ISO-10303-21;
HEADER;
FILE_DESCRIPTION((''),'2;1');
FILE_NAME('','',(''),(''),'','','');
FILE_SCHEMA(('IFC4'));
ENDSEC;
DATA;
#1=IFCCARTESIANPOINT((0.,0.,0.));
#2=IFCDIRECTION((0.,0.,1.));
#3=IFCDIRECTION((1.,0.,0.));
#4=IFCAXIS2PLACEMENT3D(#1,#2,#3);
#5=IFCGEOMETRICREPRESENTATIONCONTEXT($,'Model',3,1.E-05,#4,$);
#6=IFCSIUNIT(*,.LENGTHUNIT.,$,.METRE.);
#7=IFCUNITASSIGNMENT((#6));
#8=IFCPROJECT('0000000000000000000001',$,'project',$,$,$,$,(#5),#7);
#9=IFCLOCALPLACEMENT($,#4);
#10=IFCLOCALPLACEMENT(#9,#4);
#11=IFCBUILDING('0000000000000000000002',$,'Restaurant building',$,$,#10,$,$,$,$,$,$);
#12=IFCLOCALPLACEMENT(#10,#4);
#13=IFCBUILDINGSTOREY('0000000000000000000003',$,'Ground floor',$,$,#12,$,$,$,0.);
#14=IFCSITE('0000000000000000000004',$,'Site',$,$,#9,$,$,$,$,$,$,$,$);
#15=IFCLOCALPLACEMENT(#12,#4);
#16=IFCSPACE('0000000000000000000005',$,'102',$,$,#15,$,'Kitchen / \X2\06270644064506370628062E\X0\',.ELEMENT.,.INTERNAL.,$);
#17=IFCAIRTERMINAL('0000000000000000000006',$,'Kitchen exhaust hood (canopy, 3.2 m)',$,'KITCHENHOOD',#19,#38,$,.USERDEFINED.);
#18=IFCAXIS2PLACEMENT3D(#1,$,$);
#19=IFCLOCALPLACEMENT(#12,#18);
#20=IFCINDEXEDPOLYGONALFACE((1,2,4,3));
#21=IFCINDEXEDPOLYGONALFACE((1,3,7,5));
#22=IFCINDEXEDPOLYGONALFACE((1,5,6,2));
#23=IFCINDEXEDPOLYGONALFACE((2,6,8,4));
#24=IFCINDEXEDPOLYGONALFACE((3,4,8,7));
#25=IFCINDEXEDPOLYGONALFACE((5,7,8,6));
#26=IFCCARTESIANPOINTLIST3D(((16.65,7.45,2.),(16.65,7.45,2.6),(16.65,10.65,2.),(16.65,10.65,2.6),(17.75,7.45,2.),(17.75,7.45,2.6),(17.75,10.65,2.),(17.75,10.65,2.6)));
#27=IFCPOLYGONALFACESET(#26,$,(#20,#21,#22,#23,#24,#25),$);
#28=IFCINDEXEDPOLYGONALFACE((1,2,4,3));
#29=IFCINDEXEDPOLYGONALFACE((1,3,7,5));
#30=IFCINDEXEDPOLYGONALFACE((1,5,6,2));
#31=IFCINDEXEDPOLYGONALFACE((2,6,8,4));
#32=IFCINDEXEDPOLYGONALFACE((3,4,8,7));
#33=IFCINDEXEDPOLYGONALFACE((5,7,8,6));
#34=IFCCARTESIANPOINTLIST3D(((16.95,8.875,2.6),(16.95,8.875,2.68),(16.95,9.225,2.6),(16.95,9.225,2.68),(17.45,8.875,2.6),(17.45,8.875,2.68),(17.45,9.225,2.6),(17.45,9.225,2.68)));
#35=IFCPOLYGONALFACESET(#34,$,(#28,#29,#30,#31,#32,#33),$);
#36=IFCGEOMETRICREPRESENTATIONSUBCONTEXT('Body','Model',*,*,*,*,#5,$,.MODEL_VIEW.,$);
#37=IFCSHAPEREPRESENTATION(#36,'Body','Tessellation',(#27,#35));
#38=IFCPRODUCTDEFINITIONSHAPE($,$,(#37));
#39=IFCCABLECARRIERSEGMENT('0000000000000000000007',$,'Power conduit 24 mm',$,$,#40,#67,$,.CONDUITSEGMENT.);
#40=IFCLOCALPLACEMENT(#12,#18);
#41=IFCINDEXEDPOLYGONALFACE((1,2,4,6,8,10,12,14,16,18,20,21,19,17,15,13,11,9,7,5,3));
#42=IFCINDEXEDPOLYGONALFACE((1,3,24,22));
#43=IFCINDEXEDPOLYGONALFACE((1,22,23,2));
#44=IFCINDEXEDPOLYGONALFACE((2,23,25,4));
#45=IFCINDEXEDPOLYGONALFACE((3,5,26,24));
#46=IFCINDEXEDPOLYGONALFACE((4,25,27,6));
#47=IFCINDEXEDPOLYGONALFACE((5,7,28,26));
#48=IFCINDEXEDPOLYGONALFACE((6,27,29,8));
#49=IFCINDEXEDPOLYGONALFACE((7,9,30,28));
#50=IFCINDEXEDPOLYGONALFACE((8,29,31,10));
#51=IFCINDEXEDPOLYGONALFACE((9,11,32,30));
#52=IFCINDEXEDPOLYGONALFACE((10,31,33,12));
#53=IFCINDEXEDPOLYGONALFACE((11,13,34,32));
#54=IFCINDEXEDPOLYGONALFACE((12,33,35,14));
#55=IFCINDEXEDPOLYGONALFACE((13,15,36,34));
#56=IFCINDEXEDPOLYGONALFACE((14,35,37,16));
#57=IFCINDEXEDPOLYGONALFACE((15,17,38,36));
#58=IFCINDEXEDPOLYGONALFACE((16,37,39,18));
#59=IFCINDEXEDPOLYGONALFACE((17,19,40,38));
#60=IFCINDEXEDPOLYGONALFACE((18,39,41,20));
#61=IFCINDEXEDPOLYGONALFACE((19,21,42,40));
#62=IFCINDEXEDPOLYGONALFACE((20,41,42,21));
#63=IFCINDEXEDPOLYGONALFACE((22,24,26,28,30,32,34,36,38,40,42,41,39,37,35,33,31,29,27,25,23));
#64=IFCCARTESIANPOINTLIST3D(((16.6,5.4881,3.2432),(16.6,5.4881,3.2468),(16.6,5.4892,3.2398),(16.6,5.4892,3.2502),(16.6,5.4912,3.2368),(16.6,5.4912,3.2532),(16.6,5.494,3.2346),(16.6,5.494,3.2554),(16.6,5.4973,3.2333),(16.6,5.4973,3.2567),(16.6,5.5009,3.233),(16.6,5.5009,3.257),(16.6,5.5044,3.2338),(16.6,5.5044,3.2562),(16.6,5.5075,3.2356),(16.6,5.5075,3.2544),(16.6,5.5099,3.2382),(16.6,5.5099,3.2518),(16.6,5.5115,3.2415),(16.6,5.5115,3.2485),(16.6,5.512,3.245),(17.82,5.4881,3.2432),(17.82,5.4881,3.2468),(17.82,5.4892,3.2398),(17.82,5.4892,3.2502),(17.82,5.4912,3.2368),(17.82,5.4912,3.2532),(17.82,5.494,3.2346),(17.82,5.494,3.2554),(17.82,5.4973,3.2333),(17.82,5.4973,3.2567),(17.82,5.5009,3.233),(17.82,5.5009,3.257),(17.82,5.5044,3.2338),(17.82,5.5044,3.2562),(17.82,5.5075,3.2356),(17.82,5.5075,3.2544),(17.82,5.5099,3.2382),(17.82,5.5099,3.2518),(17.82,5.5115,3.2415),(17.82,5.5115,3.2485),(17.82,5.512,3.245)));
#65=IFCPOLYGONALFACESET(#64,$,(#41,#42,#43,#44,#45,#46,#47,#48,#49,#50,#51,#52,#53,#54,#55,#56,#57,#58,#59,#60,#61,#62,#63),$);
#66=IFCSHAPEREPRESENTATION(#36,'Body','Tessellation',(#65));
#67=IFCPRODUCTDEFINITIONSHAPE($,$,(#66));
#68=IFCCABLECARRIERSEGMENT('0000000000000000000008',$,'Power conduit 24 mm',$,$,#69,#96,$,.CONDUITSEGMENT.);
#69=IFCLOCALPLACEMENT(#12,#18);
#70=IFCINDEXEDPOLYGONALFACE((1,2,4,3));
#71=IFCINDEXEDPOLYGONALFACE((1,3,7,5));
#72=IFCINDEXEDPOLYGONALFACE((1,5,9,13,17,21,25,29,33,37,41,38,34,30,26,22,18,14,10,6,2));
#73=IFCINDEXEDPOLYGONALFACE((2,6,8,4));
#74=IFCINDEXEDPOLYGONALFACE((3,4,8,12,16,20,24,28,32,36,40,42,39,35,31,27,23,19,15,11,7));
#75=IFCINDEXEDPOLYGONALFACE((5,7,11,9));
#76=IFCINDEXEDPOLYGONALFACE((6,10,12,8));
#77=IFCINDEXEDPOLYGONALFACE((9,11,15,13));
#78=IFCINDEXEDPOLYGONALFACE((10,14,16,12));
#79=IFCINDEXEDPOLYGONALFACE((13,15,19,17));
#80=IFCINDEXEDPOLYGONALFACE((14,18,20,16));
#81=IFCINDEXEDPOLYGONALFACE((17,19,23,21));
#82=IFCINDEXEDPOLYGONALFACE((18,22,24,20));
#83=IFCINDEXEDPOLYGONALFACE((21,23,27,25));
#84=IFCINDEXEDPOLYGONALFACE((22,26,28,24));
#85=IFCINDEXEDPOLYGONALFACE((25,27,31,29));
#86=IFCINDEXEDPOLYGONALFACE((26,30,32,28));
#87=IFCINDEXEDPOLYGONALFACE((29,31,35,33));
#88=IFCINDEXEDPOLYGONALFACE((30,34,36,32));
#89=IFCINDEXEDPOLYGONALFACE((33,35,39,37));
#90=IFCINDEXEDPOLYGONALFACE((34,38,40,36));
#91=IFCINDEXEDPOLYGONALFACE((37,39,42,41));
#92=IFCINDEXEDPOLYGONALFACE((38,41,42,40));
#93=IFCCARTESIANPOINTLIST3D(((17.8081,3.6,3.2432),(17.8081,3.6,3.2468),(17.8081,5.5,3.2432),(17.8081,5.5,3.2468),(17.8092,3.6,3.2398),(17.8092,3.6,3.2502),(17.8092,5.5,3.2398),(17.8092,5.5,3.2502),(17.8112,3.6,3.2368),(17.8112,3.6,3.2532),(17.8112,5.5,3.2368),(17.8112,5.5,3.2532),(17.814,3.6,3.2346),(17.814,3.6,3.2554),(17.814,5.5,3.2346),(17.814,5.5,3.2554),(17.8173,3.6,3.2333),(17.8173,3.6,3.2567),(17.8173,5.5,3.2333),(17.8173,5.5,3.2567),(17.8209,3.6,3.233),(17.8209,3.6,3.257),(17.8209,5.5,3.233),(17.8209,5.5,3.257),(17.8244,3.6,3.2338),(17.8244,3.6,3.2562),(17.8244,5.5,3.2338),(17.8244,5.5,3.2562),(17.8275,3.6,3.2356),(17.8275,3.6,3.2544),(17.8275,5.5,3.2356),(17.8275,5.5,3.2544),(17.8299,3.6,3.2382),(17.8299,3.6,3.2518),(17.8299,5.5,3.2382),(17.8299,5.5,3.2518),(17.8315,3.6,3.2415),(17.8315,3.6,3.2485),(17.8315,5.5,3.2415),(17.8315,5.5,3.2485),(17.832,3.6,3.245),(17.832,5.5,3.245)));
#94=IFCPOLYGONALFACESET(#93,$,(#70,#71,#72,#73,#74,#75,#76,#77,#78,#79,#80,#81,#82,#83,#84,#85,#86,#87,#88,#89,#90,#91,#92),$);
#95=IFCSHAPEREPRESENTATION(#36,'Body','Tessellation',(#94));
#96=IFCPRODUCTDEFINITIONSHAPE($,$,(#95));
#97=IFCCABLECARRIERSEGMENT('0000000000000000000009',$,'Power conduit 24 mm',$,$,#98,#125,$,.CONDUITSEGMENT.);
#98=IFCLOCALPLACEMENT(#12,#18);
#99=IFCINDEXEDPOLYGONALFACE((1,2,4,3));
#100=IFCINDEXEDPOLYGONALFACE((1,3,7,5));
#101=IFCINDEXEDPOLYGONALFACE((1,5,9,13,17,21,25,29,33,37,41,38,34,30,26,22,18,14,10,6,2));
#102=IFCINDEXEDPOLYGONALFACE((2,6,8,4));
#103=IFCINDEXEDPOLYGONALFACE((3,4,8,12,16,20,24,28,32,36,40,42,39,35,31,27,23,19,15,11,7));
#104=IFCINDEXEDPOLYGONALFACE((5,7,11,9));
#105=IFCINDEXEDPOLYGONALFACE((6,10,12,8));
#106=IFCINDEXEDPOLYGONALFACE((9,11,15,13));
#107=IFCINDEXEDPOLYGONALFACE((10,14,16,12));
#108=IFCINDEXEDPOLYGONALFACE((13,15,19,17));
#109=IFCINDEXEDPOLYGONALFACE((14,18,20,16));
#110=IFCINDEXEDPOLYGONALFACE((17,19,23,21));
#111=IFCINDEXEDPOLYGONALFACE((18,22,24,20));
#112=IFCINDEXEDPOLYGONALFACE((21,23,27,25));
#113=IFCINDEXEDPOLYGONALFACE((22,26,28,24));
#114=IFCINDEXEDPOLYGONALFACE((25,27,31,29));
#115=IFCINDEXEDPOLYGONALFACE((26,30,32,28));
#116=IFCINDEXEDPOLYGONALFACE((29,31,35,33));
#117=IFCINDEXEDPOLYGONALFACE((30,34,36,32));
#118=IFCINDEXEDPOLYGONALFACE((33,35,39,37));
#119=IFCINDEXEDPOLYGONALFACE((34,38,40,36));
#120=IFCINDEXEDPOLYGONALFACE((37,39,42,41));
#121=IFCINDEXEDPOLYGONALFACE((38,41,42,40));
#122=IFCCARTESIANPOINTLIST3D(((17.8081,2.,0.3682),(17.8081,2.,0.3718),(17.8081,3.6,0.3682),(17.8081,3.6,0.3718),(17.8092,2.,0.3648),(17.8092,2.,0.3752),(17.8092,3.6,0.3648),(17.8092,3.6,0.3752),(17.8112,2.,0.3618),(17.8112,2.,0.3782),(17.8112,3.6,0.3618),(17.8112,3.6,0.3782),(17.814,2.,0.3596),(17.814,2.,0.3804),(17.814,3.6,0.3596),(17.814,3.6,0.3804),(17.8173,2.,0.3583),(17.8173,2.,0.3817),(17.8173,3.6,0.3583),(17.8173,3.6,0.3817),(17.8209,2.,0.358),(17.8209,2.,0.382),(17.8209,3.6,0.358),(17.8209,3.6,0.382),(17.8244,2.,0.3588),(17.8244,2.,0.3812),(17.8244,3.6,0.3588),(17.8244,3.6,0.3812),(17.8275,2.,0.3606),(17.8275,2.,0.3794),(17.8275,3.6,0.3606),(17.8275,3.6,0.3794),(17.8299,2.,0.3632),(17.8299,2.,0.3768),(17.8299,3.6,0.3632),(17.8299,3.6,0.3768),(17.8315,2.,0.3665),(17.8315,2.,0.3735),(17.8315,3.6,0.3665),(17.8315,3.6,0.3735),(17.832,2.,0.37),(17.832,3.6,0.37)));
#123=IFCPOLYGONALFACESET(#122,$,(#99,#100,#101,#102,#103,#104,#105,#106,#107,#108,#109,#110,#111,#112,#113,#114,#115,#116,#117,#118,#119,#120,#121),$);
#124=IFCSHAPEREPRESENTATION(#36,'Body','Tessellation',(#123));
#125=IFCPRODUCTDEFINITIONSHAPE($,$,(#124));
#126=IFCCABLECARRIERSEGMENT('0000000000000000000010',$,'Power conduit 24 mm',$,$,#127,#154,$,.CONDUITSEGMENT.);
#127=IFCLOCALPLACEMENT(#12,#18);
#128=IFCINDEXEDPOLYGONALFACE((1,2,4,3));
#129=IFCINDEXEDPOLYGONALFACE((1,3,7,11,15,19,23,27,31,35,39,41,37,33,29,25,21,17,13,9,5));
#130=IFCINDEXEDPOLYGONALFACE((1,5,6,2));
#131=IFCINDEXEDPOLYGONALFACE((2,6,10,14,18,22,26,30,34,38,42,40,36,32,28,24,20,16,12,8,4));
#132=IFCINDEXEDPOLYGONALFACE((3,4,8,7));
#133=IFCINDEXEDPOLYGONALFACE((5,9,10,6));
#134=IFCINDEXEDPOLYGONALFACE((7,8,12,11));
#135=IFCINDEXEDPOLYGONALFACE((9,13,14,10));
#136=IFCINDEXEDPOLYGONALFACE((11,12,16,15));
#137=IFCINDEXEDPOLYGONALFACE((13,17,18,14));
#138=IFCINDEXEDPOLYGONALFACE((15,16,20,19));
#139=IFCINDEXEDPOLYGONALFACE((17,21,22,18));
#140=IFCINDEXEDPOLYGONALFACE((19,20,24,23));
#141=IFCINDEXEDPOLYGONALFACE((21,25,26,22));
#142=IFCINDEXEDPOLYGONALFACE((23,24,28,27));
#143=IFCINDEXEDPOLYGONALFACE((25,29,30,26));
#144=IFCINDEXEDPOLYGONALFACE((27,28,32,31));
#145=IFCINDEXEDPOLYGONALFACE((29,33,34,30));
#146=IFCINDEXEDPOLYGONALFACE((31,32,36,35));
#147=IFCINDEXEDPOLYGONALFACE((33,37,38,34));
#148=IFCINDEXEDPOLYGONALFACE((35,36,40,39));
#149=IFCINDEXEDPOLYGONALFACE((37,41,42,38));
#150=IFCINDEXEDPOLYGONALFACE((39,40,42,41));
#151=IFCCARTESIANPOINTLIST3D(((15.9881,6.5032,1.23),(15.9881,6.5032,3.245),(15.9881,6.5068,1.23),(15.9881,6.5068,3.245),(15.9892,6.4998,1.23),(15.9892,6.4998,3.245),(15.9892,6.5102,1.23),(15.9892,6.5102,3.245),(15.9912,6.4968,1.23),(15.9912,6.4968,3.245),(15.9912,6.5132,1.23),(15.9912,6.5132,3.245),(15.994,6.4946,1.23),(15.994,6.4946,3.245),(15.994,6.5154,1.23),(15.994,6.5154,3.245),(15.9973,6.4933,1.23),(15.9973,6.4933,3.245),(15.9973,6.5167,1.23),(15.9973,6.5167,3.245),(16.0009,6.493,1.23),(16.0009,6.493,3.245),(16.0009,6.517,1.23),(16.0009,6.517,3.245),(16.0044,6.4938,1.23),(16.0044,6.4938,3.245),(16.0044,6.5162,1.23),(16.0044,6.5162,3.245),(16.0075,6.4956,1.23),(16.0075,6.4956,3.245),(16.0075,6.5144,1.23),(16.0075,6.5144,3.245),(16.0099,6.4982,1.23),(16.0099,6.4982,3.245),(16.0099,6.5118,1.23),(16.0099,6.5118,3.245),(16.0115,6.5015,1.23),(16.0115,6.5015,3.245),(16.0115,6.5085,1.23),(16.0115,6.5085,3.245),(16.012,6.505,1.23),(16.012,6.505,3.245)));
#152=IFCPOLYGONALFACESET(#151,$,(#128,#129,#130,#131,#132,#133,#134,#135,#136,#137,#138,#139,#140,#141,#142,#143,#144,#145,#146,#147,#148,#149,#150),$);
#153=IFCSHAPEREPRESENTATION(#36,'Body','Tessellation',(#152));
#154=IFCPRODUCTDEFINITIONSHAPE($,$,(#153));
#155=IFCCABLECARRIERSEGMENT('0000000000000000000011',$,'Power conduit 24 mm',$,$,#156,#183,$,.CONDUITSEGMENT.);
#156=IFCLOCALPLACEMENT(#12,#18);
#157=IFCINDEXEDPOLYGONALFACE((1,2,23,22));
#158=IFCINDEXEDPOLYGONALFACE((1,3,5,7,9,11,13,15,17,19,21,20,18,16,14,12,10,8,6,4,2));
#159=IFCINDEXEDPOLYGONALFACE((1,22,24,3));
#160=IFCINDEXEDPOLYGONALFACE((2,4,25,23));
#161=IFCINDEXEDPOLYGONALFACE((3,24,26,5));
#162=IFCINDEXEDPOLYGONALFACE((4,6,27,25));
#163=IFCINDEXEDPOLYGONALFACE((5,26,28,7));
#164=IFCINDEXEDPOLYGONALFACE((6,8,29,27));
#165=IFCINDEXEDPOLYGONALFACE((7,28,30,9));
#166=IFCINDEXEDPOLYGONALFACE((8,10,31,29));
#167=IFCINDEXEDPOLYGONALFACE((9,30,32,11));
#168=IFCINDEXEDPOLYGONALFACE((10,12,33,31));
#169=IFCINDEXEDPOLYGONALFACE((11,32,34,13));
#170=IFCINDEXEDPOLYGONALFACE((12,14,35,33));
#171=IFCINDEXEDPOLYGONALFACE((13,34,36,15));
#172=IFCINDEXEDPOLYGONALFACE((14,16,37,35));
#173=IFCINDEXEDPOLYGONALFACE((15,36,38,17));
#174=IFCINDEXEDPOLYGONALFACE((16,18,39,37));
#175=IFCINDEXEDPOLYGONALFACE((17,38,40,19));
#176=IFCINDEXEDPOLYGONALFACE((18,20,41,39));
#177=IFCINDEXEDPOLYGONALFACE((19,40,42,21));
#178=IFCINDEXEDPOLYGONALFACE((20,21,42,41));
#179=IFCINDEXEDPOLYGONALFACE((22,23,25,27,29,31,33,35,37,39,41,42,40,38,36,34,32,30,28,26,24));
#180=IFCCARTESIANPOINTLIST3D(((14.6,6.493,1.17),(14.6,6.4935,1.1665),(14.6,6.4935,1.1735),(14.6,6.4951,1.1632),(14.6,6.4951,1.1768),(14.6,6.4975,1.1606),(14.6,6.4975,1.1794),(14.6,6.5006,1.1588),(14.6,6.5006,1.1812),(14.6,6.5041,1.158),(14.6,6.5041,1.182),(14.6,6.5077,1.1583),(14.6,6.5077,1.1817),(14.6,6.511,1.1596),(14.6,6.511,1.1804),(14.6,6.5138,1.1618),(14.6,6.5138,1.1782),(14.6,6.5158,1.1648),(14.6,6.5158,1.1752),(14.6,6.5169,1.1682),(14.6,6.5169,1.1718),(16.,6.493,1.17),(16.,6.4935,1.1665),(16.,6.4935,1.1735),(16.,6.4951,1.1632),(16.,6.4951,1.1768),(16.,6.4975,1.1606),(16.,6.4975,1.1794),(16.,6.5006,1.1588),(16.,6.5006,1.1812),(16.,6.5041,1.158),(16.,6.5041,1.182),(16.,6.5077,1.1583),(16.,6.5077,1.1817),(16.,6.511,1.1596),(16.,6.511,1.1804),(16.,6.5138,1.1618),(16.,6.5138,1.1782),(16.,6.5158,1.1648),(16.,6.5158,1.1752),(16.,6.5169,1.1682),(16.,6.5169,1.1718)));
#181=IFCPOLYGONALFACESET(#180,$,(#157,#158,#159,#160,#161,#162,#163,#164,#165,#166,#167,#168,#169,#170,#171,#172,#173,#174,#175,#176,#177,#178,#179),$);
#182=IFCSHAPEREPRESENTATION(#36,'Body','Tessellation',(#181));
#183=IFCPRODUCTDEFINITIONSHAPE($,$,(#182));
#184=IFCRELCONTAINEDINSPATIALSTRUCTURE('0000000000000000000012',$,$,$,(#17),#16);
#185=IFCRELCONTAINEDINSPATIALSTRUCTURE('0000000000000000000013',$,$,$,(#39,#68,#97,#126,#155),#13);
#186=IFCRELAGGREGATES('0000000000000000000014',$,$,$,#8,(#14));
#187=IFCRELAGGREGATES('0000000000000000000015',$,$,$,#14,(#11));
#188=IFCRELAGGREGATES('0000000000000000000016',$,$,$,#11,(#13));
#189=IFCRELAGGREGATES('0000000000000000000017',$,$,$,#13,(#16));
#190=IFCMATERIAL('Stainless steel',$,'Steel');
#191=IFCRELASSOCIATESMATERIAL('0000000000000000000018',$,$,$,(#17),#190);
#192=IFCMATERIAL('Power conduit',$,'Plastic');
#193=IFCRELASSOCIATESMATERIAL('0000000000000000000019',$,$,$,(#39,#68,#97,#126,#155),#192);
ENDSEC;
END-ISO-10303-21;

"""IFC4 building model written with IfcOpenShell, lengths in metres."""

from ifc_helpers import new_model, si_unit, frame, origin_with_axes, origin_2d, place, context, subcontext, project, spatial, rectangle, circle, extrude, material, element, save


model = new_model("IFC4")

# Units and contexts
model_context = context("Model", 3, precision=1e-05, world=origin_with_axes())
body_context = subcontext(model_context, "Body", "Model", "MODEL_VIEW")
ifc_project = project(units=[si_unit("LENGTHUNIT", "METRE")], contexts=[model_context])

# Site, building, storey
site_placement = place(None, origin_with_axes())
site = spatial("IfcSite", under=ifc_project, at=site_placement, Name="Site")
building_placement = place(site_placement, origin_with_axes())
building = spatial("IfcBuilding", under=site, at=building_placement, Name="Restaurant building")
storey_placement = place(building_placement, origin_with_axes())
storey = spatial("IfcBuildingStorey", under=building, at=storey_placement, Name="Ground floor", Elevation=0.0)

# Shared definitions
space_1_placement = place(storey_placement, origin_with_axes())
space_1 = spatial("IfcSpace", under=storey, at=space_1_placement, Name="102", LongName="Kitchen / المطبخ", CompositionType="ELEMENT", PredefinedType="INTERNAL")

# Air terminal
ifc_material_1 = material(Name="Stainless steel", Category="Steel")
air_terminal_placement = place(storey_placement, frame((16.65, 7.45, 0.0)))
element("IfcAirTerminal", 1, at=air_terminal_placement, inside=space_1, material=ifc_material_1, Name="Kitchen exhaust hood (canopy, 3.2 m)", ObjectType="KITCHENHOOD", PredefinedType="USERDEFINED", context=body_context, shape_type="SweptSolid", body=[
    extrude(rectangle(XDim=1.1, YDim=3.2, at=origin_2d()), frame((0.55, 1.6, 2.0)), (0.0, 0.0, 1.0), 0.6),
    extrude(rectangle(XDim=0.5, YDim=0.35, at=origin_2d()), frame((0.55, 1.6, 2.6)), (0.0, 0.0, 1.0), 0.08),
])

# Cable carrier segments
ifc_material_2 = material(Name="Power conduit", Category="Plastic")
cable_carrier_segment_1_placement = place(storey_placement, frame((16.6, 5.5, 3.245)))
element("IfcCableCarrierSegment", 2, at=cable_carrier_segment_1_placement, inside=storey, material=ifc_material_2, Name="Power conduit 24 mm", PredefinedType="CONDUITSEGMENT", context=body_context, shape_type="SweptSolid", body=[
    extrude(circle(Radius=0.012, at=origin_2d()), frame((0.0, 0.0, 0.0), z_axis=(1.0, 0.0, 0.0), x_axis=(0.0, 1.0, 0.0)), (0.0, 0.0, 1.0), 1.22),
])
cable_carrier_segment_2_placement = place(storey_placement, frame((17.82, 5.5, 3.245)))
element("IfcCableCarrierSegment", 3, at=cable_carrier_segment_2_placement, inside=storey, material=ifc_material_2, Name="Power conduit 24 mm", PredefinedType="CONDUITSEGMENT", context=body_context, shape_type="SweptSolid", body=[
    extrude(circle(Radius=0.012, at=origin_2d()), frame((0.0, 0.0, 0.0), z_axis=(0.0, -1.0, 0.0), x_axis=(1.0, 0.0, 0.0)), (0.0, 0.0, 1.0), 1.9),
])
cable_carrier_segment_3_placement = place(storey_placement, frame((17.82, 3.6, 0.37)))
element("IfcCableCarrierSegment", 4, at=cable_carrier_segment_3_placement, inside=storey, material=ifc_material_2, Name="Power conduit 24 mm", PredefinedType="CONDUITSEGMENT", context=body_context, shape_type="SweptSolid", body=[
    extrude(circle(Radius=0.012, at=origin_2d()), frame((0.0, 0.0, 0.0), z_axis=(0.0, -1.0, 0.0), x_axis=(1.0, 0.0, 0.0)), (0.0, 0.0, 1.0), 1.6),
])
cable_carrier_segment_4_placement = place(storey_placement, frame((16.0, 6.505, 3.245)))
element("IfcCableCarrierSegment", 5, at=cable_carrier_segment_4_placement, inside=storey, material=ifc_material_2, Name="Power conduit 24 mm", PredefinedType="CONDUITSEGMENT", context=body_context, shape_type="SweptSolid", body=[
    extrude(circle(Radius=0.012, at=origin_2d()), frame((0.0, 0.0, 0.0), z_axis=(0.0, 0.0, -1.0), x_axis=(1.0, 0.0, 0.0)), (0.0, 0.0, 1.0), 2.015),
])
cable_carrier_segment_5_placement = place(storey_placement, frame((16.0, 6.505, 1.17)))
element("IfcCableCarrierSegment", 6, at=cable_carrier_segment_5_placement, inside=storey, material=ifc_material_2, Name="Power conduit 24 mm", PredefinedType="CONDUITSEGMENT", context=body_context, shape_type="SweptSolid", body=[
    extrude(circle(Radius=0.012, at=origin_2d()), frame((0.0, 0.0, 0.0), z_axis=(-1.0, 0.0, 0.0), x_axis=(0.0, -1.0, 0.0)), (0.0, 0.0, 1.0), 1.4),
])

save(model, "model.ifc")
